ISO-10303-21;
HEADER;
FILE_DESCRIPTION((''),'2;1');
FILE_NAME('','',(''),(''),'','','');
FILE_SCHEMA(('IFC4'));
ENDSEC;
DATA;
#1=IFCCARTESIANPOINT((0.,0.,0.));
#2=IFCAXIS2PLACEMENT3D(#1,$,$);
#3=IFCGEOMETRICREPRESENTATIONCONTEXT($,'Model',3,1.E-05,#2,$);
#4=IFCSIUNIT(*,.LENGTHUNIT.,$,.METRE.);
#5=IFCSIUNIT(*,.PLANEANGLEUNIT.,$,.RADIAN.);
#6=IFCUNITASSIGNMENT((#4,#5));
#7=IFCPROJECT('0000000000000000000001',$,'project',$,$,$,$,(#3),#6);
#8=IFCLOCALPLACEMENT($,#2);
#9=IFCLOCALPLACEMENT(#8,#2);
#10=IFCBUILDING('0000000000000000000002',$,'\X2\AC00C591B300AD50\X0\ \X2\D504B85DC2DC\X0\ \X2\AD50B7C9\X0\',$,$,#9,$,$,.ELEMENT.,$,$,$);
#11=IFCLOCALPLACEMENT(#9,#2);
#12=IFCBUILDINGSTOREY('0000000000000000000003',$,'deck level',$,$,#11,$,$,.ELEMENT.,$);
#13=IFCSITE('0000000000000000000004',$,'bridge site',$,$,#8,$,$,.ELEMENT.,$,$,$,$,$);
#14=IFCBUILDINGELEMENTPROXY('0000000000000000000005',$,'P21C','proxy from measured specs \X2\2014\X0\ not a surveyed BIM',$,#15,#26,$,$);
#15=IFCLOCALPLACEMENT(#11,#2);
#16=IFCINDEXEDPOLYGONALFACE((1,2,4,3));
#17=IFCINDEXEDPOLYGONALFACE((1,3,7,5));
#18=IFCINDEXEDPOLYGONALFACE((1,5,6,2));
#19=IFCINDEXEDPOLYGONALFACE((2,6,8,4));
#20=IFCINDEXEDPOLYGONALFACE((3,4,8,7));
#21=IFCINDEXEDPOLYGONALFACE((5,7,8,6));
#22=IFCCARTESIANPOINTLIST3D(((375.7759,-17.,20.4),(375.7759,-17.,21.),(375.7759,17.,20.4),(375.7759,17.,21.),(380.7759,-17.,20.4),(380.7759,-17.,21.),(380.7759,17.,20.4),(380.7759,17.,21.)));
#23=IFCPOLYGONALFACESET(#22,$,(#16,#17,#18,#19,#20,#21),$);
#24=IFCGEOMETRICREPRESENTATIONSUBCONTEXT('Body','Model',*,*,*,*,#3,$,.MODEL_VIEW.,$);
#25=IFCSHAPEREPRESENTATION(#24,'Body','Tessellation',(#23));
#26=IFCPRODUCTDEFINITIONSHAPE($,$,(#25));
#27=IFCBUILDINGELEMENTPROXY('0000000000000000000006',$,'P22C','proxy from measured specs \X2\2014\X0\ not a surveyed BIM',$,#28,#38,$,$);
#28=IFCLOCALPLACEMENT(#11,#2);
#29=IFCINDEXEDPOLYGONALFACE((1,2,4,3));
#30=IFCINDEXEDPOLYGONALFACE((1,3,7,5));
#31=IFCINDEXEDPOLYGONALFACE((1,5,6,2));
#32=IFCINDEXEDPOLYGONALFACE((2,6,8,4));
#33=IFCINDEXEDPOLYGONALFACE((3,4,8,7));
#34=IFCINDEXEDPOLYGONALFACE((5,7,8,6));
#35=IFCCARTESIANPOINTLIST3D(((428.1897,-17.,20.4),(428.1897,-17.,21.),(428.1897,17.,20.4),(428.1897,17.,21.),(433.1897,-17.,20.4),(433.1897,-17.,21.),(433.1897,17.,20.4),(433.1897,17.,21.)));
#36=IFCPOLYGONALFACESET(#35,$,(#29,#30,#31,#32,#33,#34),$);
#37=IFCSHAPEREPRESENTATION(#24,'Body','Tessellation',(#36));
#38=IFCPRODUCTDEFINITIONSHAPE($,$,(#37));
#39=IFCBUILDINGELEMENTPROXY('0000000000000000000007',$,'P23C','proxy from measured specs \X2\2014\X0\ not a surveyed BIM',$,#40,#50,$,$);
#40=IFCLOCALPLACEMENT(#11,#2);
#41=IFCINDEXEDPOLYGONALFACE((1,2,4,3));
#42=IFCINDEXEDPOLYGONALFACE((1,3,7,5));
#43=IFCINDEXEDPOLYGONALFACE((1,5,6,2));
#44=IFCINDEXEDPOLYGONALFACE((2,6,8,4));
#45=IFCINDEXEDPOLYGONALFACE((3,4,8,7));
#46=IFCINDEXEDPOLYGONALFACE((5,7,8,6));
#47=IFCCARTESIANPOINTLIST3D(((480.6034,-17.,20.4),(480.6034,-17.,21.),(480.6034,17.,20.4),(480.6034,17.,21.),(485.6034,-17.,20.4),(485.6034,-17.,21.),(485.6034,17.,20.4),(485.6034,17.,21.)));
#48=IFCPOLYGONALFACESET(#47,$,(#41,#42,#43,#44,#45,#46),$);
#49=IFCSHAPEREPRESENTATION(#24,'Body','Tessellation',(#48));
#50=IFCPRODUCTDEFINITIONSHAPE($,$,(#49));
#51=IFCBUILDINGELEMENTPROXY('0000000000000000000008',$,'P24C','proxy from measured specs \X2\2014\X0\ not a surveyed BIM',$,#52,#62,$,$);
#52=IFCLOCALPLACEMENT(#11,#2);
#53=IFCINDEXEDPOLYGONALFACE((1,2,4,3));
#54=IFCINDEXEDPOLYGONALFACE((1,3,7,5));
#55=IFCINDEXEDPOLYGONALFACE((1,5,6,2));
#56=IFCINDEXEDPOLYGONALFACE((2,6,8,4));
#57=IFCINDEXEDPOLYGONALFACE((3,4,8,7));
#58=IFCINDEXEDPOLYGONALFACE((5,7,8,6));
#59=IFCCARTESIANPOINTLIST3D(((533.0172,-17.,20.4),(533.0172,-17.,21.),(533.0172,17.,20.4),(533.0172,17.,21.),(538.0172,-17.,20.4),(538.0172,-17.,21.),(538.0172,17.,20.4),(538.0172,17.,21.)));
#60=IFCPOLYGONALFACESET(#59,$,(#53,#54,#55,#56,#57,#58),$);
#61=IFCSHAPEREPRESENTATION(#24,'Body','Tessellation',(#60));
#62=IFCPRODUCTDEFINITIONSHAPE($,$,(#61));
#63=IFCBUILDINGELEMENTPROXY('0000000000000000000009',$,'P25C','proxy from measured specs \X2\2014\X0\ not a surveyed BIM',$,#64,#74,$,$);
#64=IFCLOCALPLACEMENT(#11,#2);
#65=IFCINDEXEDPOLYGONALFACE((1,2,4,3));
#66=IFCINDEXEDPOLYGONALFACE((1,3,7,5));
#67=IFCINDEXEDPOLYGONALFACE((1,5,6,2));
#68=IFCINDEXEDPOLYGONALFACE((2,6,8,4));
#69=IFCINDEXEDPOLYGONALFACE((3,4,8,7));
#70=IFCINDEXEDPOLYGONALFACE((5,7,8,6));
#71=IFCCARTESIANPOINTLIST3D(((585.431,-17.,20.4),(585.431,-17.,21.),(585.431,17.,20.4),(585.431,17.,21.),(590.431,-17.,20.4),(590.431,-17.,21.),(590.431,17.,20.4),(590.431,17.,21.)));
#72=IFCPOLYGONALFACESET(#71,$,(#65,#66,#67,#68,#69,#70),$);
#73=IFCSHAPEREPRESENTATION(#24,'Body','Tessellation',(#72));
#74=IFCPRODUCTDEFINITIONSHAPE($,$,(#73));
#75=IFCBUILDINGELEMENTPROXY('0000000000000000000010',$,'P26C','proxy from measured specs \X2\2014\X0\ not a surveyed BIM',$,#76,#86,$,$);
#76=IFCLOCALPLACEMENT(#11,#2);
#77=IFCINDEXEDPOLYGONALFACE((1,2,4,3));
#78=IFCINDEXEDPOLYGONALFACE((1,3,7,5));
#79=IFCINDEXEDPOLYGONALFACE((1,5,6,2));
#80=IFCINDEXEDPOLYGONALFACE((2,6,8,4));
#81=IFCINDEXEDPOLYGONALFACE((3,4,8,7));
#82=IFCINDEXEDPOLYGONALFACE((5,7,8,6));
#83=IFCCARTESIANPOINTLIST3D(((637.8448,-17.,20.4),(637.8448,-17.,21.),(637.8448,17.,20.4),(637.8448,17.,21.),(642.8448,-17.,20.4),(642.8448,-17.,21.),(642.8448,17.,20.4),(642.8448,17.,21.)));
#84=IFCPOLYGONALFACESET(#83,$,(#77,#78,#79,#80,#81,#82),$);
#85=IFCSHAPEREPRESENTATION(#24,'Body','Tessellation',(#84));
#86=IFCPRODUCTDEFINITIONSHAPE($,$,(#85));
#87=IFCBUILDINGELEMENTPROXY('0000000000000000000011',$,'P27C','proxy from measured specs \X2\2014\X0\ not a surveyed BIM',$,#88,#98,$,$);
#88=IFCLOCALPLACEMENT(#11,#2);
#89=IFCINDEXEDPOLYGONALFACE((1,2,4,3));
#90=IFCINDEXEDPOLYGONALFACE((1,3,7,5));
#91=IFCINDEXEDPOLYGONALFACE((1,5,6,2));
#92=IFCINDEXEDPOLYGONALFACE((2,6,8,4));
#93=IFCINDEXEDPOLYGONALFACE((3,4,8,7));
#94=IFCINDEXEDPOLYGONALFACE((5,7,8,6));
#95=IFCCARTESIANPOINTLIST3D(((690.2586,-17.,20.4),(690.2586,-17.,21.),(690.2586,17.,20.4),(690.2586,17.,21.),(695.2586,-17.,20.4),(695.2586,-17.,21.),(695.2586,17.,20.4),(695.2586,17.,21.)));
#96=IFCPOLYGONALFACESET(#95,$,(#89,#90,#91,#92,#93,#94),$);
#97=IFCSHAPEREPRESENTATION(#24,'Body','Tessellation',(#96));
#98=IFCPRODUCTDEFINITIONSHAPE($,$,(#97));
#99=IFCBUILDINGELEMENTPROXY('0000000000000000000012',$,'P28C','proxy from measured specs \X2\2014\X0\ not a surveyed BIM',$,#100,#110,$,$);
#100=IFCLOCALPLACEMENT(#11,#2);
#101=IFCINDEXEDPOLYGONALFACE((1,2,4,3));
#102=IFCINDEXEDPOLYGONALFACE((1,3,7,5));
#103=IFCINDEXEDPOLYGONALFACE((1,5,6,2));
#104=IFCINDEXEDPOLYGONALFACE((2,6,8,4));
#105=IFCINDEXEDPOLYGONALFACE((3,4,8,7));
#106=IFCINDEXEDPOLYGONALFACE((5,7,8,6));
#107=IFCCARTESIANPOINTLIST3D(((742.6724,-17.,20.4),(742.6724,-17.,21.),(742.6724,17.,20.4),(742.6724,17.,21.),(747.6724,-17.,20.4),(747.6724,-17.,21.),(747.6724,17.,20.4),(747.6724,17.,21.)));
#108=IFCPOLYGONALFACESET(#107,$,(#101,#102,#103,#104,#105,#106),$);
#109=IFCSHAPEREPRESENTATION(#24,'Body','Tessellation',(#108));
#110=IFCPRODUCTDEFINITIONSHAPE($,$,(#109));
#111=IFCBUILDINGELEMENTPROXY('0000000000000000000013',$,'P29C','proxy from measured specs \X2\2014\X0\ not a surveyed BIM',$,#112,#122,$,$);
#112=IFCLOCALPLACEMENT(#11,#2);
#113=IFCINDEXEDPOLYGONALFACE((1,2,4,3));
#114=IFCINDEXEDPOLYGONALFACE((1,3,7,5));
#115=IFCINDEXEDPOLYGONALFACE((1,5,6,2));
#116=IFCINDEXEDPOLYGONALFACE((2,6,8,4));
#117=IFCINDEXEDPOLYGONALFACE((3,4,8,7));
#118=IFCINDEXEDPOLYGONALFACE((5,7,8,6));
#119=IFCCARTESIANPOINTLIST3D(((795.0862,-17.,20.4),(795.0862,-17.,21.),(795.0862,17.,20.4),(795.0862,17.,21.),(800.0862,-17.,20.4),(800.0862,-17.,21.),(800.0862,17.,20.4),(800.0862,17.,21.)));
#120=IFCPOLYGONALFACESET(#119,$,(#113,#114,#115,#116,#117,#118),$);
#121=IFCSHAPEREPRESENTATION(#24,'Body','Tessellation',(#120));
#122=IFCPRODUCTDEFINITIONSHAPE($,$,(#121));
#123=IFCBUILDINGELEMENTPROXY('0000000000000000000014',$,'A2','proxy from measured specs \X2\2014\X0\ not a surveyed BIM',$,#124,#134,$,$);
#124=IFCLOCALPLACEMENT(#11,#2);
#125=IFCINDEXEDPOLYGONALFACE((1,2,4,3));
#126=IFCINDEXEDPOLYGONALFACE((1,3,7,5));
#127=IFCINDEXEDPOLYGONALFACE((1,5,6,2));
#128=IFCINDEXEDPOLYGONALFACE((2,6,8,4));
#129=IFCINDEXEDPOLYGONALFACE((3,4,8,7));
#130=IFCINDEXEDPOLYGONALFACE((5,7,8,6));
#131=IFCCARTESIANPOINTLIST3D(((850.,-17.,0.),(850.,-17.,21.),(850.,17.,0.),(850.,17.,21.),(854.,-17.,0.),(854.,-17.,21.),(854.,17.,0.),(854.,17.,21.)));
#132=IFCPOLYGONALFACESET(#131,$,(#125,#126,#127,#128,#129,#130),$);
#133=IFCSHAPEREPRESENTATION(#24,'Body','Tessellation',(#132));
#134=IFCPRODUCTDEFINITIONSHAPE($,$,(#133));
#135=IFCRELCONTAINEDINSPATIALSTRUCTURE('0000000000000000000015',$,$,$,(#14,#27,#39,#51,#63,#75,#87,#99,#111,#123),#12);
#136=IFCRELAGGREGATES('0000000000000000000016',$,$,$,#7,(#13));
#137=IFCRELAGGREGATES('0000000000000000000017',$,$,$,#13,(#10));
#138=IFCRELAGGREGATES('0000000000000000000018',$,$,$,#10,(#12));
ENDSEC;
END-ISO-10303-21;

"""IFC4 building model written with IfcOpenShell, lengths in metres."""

from ifc_helpers import new_model, si_unit, frame, origin, origin_2d, place, context, subcontext, project, spatial, rectangle, extrude, element, save


model = new_model("IFC4")

# Units and contexts
model_context = context("Model", 3, precision=1e-05, world=origin())
body_context = subcontext(model_context, "Body", "Model", "MODEL_VIEW")
ifc_project = project(units=[si_unit("LENGTHUNIT", "METRE"), si_unit("PLANEANGLEUNIT", "RADIAN")], contexts=[model_context])

# Site, building, storey
site_placement = place(None, origin())
site = spatial("IfcSite", under=ifc_project, at=site_placement, Name="bridge site", CompositionType="ELEMENT")
building_placement = place(site_placement, origin())
building = spatial("IfcBuilding", under=site, at=building_placement, Name="가양대교 프록시 교량", CompositionType="ELEMENT")
storey_placement = place(building_placement, origin())
storey = spatial("IfcBuildingStorey", under=building, at=storey_placement, Name="deck level", CompositionType="ELEMENT")

# Building element proxies
for number, where, name in (
    (1, (378.2759, 0.0, 20.4), "P21C"),
    (2, (430.6897, 0.0, 20.4), "P22C"),
    (3, (483.1034, 0.0, 20.4), "P23C"),
    (4, (535.5172, 0.0, 20.4), "P24C"),
    (5, (587.931, 0.0, 20.4), "P25C"),
    (6, (640.3448, 0.0, 20.4), "P26C"),
    (7, (692.7586, 0.0, 20.4), "P27C"),
    (8, (745.1724, 0.0, 20.4), "P28C"),
    (9, (797.5862, 0.0, 20.4), "P29C"),
):
    element("IfcBuildingElementProxy", number, at=place(storey_placement, frame(where)), inside=storey, Name=name, Description="proxy from measured specs — not a surveyed BIM", context=body_context, shape_type="SweptSolid", body=[
        extrude(rectangle(XDim=5.0, YDim=34.0, at=origin_2d()), origin(), (0.0, 0.0, 1.0), 0.6),
    ])
proxy_placement = place(storey_placement, frame((852.0, 0.0, 0.0)))
element("IfcBuildingElementProxy", 10, at=proxy_placement, inside=storey, Name="A2", Description="proxy from measured specs — not a surveyed BIM", context=body_context, shape_type="SweptSolid", body=[
    extrude(rectangle(XDim=4.0, YDim=34.0, at=origin_2d()), origin(), (0.0, 0.0, 1.0), 21.0),
])

save(model, "model.ifc")
